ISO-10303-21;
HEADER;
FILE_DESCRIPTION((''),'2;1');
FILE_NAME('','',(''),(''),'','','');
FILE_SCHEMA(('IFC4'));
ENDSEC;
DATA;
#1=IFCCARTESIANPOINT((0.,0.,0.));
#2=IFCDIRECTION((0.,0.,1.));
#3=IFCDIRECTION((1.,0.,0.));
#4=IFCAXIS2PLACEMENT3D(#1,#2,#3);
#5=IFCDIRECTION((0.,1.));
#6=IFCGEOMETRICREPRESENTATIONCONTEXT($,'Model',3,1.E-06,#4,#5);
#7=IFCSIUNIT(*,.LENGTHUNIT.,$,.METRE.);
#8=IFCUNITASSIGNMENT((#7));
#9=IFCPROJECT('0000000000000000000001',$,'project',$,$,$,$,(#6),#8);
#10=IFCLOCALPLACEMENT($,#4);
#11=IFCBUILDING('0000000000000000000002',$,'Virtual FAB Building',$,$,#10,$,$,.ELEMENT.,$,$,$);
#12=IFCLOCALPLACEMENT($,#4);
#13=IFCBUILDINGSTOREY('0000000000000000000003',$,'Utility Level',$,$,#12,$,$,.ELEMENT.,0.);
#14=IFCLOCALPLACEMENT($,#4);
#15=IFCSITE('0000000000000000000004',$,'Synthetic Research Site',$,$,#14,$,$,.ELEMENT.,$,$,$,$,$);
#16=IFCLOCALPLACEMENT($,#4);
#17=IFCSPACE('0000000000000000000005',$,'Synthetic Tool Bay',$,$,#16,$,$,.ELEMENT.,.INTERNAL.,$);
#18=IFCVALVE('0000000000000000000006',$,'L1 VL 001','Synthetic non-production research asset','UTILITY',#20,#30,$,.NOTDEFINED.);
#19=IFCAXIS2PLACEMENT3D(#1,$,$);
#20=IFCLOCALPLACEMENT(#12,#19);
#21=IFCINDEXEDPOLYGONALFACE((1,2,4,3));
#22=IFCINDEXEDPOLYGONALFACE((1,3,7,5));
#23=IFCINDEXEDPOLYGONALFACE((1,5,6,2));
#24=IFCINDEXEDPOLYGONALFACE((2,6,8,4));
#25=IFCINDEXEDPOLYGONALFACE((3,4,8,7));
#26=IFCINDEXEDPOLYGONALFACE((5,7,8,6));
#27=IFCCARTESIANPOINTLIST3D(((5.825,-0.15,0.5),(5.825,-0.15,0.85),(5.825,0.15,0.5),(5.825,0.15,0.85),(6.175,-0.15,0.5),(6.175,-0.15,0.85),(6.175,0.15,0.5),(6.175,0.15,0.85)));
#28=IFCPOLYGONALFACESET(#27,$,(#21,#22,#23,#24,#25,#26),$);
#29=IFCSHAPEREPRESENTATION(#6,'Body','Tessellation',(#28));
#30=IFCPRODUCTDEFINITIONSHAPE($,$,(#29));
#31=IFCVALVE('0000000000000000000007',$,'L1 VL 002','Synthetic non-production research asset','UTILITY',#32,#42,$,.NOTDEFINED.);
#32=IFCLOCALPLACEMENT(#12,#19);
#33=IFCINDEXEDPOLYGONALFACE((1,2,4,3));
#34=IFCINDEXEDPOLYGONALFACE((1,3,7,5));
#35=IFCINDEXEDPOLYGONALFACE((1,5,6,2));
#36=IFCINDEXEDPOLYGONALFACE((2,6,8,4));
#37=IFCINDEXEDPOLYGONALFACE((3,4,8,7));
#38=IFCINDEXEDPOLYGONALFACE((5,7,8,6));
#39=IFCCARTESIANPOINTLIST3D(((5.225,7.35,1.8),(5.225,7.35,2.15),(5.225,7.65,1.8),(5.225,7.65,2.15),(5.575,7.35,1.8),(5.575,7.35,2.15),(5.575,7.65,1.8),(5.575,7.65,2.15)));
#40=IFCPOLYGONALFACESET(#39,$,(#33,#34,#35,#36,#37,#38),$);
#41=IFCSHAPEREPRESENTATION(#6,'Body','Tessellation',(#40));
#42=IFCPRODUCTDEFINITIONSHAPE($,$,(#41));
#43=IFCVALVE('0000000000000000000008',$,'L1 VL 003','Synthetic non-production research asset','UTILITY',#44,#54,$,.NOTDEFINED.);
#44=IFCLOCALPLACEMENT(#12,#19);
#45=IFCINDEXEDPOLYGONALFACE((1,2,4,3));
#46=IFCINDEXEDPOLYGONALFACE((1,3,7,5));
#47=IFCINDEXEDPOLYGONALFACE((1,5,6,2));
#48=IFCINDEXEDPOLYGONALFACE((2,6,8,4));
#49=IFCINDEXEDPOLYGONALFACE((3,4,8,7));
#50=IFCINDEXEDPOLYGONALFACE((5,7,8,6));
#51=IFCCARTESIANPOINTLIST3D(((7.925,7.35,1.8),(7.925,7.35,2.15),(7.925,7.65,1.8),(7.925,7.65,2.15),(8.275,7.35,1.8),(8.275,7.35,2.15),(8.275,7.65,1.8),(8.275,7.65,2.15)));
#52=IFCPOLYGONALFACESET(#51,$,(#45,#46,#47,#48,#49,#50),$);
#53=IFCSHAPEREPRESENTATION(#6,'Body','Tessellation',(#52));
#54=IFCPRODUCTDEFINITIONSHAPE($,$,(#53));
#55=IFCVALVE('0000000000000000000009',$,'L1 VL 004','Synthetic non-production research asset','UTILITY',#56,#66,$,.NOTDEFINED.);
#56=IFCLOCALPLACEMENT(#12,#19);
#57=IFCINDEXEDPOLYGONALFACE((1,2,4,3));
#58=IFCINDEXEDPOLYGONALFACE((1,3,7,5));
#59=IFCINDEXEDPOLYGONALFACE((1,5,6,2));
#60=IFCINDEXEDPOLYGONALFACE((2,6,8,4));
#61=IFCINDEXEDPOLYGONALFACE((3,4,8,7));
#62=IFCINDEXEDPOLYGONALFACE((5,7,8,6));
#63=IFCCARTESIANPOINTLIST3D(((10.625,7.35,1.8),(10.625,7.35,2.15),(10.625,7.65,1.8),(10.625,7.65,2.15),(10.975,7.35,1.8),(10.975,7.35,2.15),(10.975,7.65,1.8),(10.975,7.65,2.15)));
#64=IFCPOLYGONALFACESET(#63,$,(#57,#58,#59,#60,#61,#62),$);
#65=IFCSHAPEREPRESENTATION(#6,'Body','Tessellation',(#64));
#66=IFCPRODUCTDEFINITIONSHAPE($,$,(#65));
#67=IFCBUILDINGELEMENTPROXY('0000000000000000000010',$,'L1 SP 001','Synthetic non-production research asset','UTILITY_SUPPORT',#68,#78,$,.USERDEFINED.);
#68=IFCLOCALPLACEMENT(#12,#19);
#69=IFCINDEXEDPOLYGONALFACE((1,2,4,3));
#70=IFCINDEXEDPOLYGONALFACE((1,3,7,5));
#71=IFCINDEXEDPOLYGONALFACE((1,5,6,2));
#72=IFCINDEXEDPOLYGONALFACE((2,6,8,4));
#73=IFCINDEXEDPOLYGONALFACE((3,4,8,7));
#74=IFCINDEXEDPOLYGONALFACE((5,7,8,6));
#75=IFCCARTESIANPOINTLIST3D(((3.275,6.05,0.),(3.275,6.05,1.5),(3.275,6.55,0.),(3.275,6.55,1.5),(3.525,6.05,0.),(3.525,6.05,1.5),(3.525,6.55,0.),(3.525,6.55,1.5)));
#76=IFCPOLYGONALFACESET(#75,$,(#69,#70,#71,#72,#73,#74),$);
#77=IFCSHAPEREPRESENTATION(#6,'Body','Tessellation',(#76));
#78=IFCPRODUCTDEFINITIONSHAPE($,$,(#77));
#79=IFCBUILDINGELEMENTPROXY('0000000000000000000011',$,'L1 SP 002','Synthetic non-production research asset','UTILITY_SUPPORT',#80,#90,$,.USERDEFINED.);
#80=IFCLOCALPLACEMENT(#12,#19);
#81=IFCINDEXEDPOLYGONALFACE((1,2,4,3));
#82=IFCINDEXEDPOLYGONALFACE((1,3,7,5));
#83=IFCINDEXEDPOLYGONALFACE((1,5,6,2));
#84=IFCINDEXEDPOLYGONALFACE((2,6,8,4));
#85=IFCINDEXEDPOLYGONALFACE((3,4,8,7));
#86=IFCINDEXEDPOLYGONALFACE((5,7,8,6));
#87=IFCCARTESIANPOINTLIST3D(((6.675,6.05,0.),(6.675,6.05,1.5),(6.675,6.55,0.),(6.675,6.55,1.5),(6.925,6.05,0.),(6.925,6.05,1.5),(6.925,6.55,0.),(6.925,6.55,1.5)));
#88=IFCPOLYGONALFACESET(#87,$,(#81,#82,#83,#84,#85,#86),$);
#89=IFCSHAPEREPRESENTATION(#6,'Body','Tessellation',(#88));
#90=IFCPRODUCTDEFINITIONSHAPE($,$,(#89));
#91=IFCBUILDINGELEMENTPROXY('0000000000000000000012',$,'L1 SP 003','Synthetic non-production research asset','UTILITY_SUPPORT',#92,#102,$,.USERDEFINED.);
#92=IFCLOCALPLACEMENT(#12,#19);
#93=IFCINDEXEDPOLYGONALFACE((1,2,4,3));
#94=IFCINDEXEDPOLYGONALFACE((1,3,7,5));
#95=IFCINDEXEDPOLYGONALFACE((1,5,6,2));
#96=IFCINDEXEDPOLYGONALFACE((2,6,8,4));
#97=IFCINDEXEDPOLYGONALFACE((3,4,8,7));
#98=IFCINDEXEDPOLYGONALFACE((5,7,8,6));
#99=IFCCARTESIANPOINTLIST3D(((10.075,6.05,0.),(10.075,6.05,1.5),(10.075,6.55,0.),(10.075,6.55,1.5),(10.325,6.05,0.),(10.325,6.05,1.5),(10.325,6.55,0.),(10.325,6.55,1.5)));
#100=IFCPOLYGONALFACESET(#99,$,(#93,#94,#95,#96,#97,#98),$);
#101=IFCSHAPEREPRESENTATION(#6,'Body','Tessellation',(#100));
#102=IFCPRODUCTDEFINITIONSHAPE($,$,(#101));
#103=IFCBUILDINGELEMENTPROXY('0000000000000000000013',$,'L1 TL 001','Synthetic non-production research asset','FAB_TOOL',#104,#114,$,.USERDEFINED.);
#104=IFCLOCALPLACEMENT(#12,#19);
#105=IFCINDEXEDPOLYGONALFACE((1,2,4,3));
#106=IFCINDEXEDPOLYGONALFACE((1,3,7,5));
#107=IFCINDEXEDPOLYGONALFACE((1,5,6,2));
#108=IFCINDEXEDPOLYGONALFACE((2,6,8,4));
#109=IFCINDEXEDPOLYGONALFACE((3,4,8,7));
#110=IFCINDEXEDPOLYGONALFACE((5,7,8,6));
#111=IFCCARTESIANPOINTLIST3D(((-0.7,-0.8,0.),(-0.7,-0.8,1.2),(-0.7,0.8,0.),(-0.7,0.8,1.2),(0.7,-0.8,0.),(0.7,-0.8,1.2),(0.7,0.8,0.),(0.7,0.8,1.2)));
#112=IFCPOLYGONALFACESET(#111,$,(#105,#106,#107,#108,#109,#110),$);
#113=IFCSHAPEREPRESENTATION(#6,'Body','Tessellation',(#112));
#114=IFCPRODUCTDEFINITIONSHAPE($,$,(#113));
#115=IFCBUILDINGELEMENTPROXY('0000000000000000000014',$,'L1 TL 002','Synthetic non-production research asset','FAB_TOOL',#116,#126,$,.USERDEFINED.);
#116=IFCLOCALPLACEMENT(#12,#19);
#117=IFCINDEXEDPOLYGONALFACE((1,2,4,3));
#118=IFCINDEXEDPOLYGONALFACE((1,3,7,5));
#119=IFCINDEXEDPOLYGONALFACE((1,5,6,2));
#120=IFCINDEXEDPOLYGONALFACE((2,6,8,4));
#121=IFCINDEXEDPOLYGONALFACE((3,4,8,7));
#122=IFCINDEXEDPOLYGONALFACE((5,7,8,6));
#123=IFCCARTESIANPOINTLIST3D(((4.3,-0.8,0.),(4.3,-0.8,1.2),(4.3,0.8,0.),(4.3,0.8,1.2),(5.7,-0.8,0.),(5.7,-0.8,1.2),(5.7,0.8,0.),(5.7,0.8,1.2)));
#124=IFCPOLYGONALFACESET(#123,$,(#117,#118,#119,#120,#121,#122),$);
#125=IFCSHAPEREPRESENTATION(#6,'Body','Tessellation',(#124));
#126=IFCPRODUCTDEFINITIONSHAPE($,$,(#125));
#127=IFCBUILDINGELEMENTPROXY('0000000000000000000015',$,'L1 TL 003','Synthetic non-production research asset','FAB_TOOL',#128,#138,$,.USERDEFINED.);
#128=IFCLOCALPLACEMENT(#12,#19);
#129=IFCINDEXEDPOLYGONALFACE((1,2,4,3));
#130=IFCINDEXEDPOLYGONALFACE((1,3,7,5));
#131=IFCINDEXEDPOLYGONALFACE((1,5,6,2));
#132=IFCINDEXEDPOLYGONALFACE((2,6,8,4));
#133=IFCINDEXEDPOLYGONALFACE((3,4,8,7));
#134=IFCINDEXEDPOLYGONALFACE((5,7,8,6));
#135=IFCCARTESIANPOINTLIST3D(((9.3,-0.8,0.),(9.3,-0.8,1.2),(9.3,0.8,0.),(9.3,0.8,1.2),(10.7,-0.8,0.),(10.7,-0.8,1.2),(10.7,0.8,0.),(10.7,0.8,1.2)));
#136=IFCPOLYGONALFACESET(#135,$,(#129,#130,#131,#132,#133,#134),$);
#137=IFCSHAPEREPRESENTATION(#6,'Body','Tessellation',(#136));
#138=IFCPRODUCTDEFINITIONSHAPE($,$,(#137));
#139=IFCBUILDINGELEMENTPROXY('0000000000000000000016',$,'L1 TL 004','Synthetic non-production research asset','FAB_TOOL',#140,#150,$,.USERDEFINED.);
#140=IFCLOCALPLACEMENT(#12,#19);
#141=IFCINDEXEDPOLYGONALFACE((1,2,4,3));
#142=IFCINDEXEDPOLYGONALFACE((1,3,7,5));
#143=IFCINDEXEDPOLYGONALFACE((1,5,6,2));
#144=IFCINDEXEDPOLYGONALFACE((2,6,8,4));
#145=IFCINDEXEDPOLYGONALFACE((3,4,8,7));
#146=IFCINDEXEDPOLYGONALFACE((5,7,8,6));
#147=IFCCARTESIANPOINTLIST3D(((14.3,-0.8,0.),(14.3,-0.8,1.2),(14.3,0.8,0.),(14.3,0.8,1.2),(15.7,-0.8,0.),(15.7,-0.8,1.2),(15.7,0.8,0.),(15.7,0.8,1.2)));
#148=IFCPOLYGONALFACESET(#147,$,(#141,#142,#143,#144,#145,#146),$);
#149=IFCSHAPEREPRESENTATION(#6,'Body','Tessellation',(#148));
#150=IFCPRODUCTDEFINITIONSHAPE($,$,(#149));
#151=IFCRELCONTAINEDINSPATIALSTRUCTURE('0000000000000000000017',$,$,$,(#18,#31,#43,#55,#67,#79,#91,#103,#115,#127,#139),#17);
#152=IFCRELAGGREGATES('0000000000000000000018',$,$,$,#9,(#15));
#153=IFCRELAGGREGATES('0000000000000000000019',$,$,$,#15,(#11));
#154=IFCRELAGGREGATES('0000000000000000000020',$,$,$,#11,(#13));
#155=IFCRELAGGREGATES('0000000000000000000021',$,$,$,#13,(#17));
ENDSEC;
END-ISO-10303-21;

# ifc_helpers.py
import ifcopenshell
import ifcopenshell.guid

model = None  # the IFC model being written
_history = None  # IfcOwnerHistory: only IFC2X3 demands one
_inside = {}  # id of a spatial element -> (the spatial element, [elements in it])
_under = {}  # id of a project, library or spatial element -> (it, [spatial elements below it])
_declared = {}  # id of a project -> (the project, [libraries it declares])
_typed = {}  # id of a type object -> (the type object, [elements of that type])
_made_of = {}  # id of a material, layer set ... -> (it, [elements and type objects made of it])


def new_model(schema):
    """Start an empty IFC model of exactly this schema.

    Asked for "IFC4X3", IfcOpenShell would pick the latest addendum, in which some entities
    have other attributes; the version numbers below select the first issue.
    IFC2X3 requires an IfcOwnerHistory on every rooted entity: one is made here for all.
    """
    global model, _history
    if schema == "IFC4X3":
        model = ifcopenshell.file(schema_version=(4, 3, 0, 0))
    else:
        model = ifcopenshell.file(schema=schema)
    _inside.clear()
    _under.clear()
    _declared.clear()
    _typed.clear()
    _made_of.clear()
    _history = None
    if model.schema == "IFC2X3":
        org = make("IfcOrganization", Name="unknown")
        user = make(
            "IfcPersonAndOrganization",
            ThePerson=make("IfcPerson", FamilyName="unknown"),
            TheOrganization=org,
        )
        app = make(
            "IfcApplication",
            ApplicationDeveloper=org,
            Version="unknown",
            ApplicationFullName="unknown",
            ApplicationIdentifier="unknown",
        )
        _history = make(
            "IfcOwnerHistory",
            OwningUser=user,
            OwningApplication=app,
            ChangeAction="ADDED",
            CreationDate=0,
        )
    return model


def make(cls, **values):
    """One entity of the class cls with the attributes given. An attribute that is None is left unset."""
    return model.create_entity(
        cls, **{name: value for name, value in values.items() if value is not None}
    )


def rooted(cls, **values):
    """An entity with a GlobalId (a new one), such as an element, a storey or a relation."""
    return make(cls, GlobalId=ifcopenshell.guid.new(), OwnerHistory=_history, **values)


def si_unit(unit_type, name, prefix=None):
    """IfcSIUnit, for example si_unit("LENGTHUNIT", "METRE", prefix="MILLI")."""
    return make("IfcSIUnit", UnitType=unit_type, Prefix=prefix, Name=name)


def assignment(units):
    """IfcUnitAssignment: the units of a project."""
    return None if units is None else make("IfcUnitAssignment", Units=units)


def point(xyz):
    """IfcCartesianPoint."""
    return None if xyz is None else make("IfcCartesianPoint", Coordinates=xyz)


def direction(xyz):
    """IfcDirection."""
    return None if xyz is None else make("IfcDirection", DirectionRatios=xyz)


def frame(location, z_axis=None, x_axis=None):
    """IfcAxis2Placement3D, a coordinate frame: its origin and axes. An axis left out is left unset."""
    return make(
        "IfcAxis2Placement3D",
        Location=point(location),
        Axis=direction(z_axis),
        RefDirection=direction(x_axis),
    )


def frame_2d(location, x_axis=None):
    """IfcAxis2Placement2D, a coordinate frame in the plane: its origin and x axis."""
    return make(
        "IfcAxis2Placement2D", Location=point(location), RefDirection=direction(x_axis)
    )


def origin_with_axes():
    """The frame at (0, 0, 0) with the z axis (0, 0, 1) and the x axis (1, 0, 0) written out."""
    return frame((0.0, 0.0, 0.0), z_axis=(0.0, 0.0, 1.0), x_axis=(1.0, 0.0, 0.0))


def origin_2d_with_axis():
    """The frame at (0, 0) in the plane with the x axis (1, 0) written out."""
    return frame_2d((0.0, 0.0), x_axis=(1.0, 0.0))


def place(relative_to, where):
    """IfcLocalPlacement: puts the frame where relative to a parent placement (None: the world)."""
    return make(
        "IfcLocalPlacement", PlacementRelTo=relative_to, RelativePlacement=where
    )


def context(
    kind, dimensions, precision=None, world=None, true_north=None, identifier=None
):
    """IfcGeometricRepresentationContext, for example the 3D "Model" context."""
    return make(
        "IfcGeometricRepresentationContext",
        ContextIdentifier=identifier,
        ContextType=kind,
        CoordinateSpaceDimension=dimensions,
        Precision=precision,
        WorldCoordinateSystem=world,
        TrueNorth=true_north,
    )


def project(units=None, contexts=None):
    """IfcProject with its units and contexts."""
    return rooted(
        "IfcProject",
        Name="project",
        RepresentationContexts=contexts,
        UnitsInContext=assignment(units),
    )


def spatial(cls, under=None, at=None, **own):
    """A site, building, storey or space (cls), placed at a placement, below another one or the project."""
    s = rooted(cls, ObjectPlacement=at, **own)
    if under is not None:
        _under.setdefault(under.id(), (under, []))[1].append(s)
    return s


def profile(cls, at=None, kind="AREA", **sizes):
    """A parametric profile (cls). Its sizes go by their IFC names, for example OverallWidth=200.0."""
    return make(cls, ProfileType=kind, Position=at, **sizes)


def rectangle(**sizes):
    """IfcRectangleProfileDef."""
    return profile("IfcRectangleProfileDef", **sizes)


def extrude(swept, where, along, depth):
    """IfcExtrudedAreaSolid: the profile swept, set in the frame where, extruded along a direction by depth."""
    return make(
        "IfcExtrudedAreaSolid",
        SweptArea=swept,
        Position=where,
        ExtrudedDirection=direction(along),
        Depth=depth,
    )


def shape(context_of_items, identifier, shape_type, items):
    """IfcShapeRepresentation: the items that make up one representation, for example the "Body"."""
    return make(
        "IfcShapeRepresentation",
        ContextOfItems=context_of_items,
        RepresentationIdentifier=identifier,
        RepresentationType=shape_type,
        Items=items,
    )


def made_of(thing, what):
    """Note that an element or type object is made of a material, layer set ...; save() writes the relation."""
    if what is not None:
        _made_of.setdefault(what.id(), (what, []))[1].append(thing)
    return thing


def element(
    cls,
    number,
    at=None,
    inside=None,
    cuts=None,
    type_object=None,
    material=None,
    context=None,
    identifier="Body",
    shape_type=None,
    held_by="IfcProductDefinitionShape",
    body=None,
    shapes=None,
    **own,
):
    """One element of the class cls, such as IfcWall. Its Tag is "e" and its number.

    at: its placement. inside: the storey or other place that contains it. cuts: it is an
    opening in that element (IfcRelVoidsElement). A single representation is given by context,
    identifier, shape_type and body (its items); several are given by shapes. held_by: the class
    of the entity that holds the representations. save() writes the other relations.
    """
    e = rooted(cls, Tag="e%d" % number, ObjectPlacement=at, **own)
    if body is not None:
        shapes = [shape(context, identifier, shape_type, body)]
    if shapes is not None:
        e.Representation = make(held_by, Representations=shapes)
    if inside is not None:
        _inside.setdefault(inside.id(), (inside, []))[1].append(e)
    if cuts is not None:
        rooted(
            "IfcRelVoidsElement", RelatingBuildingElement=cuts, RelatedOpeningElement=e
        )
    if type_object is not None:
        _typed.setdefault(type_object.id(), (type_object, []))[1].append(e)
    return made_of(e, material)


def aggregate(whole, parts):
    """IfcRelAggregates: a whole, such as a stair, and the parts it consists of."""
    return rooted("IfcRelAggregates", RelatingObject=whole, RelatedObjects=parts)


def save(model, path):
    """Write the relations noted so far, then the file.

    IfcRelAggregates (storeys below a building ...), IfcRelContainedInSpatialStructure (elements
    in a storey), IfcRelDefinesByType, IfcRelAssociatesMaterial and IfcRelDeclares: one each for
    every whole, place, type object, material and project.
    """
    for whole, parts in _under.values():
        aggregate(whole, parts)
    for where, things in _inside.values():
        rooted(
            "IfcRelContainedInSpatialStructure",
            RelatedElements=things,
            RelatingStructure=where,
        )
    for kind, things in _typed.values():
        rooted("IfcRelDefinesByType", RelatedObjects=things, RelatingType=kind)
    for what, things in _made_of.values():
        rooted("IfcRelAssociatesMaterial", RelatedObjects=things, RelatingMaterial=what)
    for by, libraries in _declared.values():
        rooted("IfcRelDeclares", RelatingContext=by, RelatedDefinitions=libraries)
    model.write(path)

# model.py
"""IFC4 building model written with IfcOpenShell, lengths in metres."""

from ifc_helpers import new_model, si_unit, direction, frame, origin_with_axes, origin_2d_with_axis, place, context, project, spatial, rectangle, extrude, element, save


model = new_model("IFC4")

# Units and contexts
model_context = context("Model", 3, precision=1e-06, world=origin_with_axes(), true_north=direction((0.0, 1.0)))
ifc_project = project(units=[si_unit("LENGTHUNIT", "METRE")], contexts=[model_context])

# Site, building, storey, space
site_placement = place(None, origin_with_axes())
site = spatial("IfcSite", under=ifc_project, at=site_placement, Name="Synthetic Research Site", CompositionType="ELEMENT")
building_placement = place(None, origin_with_axes())
building = spatial("IfcBuilding", under=site, at=building_placement, Name="Virtual FAB Building", CompositionType="ELEMENT")
storey_placement = place(None, origin_with_axes())
storey = spatial("IfcBuildingStorey", under=building, at=storey_placement, Name="Utility Level", CompositionType="ELEMENT", Elevation=0.0)
space_placement = place(None, origin_with_axes())
space = spatial("IfcSpace", under=storey, at=space_placement, Name="Synthetic Tool Bay", CompositionType="ELEMENT", PredefinedType="INTERNAL")

# Valves
for number, where, z_axis, x_axis, name in (
    (1, (6.0, 0.0, 0.5), (0.0, 0.0, 1.0), (1.0, 0.0, 0.0), "L1 VL 001"),
    (2, (5.4, 7.5, 1.8), (0.0, 0.0, 1.0), (1.0, 0.0, 0.0), "L1 VL 002"),
    (3, (8.1, 7.5, 1.8), (0.0, 0.0, 1.0), (1.0, 0.0, 0.0), "L1 VL 003"),
    (4, (10.8, 7.5, 1.8), (0.0, 0.0, 1.0), (1.0, 0.0, 0.0), "L1 VL 004"),
):
    element("IfcValve", number, at=place(None, frame(where, z_axis=z_axis, x_axis=x_axis)), inside=space, Name=name, Description="Synthetic non-production research asset", ObjectType="UTILITY", PredefinedType="NOTDEFINED", context=model_context, shape_type="SweptSolid", body=[
        extrude(rectangle(XDim=0.35, YDim=0.3, at=origin_2d_with_axis()), origin_with_axes(), (0.0, 0.0, 1.0), 0.35),
    ])

# Building element proxies
for number, where, z_axis, x_axis, name in (
    (5, (3.4, 6.3, 0.0), (0.0, 0.0, 1.0), (1.0, 0.0, 0.0), "L1 SP 001"),
    (6, (6.8, 6.3, 0.0), (0.0, 0.0, 1.0), (1.0, 0.0, 0.0), "L1 SP 002"),
    (7, (10.2, 6.3, 0.0), (0.0, 0.0, 1.0), (1.0, 0.0, 0.0), "L1 SP 003"),
):
    element("IfcBuildingElementProxy", number, at=place(None, frame(where, z_axis=z_axis, x_axis=x_axis)), inside=space, Name=name, Description="Synthetic non-production research asset", ObjectType="UTILITY_SUPPORT", PredefinedType="USERDEFINED", context=model_context, shape_type="SweptSolid", body=[
        extrude(rectangle(XDim=0.25, YDim=0.5, at=origin_2d_with_axis()), origin_with_axes(), (0.0, 0.0, 1.0), 1.5),
    ])
for number, where, z_axis, x_axis, name in (
    (8, (0.0, 0.0, 0.0), (0.0, 0.0, 1.0), (1.0, 0.0, 0.0), "L1 TL 001"),
    (9, (5.0, 0.0, 0.0), (0.0, 0.0, 1.0), (1.0, 0.0, 0.0), "L1 TL 002"),
    (10, (10.0, 0.0, 0.0), (0.0, 0.0, 1.0), (1.0, 0.0, 0.0), "L1 TL 003"),
    (11, (15.0, 0.0, 0.0), (0.0, 0.0, 1.0), (1.0, 0.0, 0.0), "L1 TL 004"),
):
    element("IfcBuildingElementProxy", number, at=place(None, frame(where, z_axis=z_axis, x_axis=x_axis)), inside=space, Name=name, Description="Synthetic non-production research asset", ObjectType="FAB_TOOL", PredefinedType="USERDEFINED", context=model_context, shape_type="SweptSolid", body=[
        extrude(rectangle(XDim=1.4, YDim=1.6, at=origin_2d_with_axis()), origin_with_axes(), (0.0, 0.0, 1.0), 1.2),
    ])

save(model, "model.ifc")
